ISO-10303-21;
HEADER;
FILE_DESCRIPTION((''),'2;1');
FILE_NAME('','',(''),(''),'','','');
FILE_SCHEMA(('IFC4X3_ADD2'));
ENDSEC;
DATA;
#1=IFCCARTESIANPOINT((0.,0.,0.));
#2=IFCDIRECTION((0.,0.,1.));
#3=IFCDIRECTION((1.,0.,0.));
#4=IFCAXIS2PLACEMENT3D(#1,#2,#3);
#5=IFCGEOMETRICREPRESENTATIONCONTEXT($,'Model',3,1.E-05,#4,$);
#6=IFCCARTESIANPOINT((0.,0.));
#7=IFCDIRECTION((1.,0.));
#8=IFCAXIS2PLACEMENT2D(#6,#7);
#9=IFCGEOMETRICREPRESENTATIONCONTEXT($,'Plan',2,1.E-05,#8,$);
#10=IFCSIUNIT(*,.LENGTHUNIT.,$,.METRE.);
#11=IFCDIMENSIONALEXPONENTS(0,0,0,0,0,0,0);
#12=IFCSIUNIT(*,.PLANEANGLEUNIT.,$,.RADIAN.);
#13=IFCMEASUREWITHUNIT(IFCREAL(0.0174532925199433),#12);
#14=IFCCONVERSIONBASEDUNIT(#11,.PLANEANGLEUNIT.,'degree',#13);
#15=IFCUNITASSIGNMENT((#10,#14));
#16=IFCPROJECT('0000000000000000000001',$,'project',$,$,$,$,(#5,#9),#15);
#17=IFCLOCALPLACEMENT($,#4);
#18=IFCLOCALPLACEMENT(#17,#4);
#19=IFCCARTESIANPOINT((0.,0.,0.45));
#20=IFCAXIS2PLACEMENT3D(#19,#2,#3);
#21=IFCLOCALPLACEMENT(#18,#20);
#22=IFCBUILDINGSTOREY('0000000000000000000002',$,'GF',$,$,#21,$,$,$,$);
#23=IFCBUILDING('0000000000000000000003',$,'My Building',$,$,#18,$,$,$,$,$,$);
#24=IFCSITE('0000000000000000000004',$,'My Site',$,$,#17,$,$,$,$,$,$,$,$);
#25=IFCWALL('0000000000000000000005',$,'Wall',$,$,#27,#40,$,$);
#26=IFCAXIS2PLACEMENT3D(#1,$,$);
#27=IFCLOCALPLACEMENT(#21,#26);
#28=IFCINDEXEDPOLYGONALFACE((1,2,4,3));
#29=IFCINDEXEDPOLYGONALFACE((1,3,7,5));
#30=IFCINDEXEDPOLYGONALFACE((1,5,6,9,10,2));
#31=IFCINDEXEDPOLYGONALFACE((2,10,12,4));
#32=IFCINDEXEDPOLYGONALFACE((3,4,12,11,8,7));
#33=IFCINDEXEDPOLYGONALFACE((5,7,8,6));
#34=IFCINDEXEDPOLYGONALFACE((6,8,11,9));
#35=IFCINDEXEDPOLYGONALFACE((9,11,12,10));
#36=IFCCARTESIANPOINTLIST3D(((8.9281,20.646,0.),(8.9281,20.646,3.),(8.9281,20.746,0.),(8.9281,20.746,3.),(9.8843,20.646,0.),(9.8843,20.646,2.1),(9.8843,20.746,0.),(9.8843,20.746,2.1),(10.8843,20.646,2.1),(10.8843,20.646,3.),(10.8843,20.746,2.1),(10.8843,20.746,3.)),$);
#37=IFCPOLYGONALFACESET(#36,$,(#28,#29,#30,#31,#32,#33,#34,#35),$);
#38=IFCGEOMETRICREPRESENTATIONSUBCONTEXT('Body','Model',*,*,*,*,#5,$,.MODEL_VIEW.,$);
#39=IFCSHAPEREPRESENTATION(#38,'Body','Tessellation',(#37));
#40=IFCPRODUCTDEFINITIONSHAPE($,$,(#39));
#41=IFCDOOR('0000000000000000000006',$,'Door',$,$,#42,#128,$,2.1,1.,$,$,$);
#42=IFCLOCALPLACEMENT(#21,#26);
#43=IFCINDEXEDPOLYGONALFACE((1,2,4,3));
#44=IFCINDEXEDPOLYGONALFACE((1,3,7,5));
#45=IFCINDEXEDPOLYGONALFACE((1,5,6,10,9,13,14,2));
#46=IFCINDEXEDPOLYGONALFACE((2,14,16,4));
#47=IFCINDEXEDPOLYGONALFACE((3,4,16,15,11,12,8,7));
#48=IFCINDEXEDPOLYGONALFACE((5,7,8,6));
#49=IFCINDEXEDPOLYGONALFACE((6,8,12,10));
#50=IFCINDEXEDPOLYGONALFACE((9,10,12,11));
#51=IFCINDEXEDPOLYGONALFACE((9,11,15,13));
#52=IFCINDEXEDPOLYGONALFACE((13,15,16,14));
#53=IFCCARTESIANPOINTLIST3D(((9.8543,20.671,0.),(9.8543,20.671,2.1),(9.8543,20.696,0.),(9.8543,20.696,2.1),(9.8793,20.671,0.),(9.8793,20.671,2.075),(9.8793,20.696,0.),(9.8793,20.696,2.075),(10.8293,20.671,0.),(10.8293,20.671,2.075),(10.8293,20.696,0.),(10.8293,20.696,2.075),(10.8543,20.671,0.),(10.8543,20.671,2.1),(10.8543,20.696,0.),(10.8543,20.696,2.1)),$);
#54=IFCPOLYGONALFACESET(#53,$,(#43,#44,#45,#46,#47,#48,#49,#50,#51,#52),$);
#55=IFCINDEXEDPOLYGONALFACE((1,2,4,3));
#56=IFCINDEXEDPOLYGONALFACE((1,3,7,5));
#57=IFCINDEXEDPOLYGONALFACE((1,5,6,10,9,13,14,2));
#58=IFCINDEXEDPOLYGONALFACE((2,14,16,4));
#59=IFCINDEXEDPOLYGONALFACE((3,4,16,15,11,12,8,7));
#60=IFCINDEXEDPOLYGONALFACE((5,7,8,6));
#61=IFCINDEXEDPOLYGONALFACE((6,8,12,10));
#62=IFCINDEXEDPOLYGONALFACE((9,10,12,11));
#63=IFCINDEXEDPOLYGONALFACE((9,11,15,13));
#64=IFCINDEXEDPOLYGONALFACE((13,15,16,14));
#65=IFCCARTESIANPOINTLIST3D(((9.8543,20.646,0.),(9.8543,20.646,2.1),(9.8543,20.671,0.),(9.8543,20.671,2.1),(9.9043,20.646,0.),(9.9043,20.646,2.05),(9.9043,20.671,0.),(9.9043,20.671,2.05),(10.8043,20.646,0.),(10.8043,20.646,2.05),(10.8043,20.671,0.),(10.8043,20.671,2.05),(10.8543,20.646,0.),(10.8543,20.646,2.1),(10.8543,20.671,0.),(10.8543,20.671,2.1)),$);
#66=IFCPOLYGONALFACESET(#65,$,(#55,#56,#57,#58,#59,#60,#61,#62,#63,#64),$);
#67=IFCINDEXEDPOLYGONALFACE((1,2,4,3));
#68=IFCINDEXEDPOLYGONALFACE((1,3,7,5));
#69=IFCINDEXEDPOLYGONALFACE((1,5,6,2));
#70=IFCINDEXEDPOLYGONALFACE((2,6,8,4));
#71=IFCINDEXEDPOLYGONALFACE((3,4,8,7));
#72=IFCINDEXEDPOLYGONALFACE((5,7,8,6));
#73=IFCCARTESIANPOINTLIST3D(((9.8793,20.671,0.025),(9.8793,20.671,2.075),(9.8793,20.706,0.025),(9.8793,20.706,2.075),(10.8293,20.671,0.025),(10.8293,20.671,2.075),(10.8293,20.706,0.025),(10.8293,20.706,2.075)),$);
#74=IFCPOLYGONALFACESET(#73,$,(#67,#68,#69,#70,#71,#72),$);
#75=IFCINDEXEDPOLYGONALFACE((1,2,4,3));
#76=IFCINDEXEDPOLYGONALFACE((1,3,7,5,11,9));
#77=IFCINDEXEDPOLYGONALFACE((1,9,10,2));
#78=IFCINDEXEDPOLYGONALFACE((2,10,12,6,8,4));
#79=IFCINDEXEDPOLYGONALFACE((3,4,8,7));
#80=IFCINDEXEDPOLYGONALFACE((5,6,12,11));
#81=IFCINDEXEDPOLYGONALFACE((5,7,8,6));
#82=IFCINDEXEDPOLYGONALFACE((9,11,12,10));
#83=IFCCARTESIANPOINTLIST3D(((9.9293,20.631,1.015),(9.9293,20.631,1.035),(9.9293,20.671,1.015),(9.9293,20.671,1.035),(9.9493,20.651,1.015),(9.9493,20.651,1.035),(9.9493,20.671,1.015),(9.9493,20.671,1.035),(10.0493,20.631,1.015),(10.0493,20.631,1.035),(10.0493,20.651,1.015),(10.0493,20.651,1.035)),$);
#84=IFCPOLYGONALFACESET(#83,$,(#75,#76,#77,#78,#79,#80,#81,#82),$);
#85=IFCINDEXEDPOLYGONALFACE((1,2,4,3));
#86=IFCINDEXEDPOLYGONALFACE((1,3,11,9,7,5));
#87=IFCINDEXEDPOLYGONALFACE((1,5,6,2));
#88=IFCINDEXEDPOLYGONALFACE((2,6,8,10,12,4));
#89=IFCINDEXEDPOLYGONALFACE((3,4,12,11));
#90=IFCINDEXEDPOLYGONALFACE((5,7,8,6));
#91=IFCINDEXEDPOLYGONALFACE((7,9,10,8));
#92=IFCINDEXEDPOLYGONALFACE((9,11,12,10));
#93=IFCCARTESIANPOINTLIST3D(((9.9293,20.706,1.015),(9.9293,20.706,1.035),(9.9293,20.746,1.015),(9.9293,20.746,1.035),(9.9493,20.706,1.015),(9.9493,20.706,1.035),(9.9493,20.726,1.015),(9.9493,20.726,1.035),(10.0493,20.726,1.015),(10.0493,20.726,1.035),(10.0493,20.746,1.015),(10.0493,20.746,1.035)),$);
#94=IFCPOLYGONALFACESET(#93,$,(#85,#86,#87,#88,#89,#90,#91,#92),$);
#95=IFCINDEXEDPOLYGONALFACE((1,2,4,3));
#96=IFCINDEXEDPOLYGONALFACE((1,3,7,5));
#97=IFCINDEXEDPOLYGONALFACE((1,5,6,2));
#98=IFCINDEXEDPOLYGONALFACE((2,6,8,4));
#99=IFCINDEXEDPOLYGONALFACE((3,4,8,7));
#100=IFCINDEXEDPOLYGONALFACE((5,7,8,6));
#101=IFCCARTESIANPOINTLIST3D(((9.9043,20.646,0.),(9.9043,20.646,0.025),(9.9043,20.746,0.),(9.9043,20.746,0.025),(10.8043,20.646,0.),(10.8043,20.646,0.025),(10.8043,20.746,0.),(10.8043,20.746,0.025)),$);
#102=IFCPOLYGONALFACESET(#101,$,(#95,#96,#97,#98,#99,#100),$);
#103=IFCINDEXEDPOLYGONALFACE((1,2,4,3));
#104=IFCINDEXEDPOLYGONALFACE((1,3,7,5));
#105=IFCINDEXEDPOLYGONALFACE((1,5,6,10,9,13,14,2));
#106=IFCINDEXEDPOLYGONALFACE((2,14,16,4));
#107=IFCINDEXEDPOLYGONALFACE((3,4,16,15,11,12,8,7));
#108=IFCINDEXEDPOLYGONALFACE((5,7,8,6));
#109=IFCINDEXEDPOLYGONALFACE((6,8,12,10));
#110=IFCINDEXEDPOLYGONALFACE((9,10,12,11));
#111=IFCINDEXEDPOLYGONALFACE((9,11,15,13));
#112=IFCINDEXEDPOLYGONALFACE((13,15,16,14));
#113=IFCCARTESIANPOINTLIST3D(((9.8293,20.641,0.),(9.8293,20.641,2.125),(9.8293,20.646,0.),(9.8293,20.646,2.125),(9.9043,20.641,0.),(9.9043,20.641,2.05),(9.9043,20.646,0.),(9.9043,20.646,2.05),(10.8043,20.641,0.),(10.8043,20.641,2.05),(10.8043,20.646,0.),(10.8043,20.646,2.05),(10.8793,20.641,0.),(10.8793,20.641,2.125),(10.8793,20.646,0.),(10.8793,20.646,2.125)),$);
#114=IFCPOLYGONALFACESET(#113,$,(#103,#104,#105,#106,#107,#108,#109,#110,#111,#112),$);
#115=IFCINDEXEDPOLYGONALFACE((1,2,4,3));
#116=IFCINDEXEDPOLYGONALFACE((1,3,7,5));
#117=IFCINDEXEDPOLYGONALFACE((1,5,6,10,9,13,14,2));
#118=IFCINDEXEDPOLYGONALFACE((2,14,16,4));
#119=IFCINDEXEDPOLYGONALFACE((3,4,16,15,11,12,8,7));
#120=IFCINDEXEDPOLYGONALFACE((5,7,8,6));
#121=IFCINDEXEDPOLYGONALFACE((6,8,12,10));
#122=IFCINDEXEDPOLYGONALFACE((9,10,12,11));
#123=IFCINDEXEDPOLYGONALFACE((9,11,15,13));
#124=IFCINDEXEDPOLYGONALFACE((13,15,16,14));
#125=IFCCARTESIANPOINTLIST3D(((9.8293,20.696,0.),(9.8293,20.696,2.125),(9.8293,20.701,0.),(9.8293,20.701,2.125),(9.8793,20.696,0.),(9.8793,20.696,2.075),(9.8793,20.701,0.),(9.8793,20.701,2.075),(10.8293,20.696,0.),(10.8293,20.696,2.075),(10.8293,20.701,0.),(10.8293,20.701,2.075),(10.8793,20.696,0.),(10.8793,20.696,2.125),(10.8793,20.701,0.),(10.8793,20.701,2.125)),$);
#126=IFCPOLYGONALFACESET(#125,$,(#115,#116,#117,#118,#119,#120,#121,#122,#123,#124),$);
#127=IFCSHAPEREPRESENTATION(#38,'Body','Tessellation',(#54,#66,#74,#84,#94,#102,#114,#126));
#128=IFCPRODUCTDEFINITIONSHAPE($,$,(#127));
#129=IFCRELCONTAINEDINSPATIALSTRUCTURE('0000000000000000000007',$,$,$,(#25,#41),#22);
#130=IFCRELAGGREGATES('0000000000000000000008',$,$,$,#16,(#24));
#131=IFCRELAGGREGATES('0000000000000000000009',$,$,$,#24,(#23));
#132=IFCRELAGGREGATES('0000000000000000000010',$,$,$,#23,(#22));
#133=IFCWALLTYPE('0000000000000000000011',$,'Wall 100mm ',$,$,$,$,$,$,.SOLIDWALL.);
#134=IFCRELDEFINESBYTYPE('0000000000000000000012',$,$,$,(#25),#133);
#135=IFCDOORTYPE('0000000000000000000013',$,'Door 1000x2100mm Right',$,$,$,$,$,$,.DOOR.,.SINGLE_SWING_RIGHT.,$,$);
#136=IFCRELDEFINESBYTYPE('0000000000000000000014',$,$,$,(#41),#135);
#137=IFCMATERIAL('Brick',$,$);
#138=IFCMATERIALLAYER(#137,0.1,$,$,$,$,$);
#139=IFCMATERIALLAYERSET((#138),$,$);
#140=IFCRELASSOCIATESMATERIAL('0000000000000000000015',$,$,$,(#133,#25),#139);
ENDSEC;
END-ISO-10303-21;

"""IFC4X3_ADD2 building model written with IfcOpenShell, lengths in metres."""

from ifc_helpers import new_model, entity, si_unit, converted_unit, frame, origin_with_axes, origin_2d_with_axis, place, context, subcontext, project, spatial, line, indexed_curve, outline, extrude, shape, source, transform, mapped, material, layer, layer_set, layer_usage, type_object, type_shapes, element, fill, save


model = new_model("IFC4X3_ADD2")

# Units and contexts
model_context = context("Model", 3, precision=1e-05, world=origin_with_axes())
plan_context = context("Plan", 2, precision=1e-05, world=origin_2d_with_axis())
body_context_1 = subcontext(model_context, "Body", "Model", "MODEL_VIEW")
body_context_2 = subcontext(plan_context, "Body", "Plan", "PLAN_VIEW")
ifc_project = project(units=[si_unit("LENGTHUNIT", "METRE"), converted_unit("PLANEANGLEUNIT", "degree", entity("IfcReal", 0.0174532925199433), si_unit("PLANEANGLEUNIT", "RADIAN"), dimensions=[0, 0, 0, 0, 0, 0, 0])], contexts=[model_context, plan_context])

# Site, building, storey
site_placement = place(None, origin_with_axes())
site = spatial("IfcSite", under=ifc_project, at=site_placement, Name="My Site")
building_placement = place(site_placement, origin_with_axes())
building = spatial("IfcBuilding", under=site, at=building_placement, Name="My Building")
storey_placement = place(building_placement, frame((0.0, 0.0, 0.45), z_axis=(0.0, 0.0, 1.0), x_axis=(1.0, 0.0, 0.0)))
storey = spatial("IfcBuildingStorey", under=building, at=storey_placement, Name="GF")

# Shared definitions
ifc_material = material(Name="Brick")

# Shared definitions
ifc_layer_1 = layer(ifc_material, 0.1)
ifc_layer_set_1 = layer_set([ifc_layer_1])
wall_type_1 = type_object("IfcWallType", Name="Wall 100mm ", PredefinedType="SOLIDWALL", material=ifc_layer_set_1)
shared_shape_1 = source(origin_with_axes(), body_context_1, "Body", "SweptSolid", [
    extrude(outline(indexed_curve([(0.0, 0.0), (1.0, 0.0), (1.0, 2.1), (0.0, 2.1)], segments=[line(1, 2, 3, 4, 1)])), frame((0.0, -0.6, 0.0), z_axis=(0.0, -1.0, 0.0), x_axis=(1.0, 0.0, 0.0)), (0.0, 0.0, -1.0), 1.2),
])
door_type_1 = type_object("IfcDoorType", Name="Door 1000x2100mm Right", OperationType="SINGLE_SWING_RIGHT", PredefinedType="DOOR")
shared_shape_2 = source(origin_with_axes(), body_context_1, "Body", "SweptSolid", [
    extrude(outline(indexed_curve([(0.0, 0.0), (0.0, 2.1), (1.0, 2.1), (1.0, 0.0), (0.975, 0.0), (0.975, 2.075), (0.025, 2.075), (0.025, 0.0)], segments=[line(1, 2, 3, 4, 5, 6, 7, 8, 1)])), frame((0.0, 0.025, 0.0), z_axis=(0.0, -1.0, 0.0), x_axis=(1.0, 0.0, 0.0)), (0.0, 0.0, -1.0), 0.025),
    extrude(outline(indexed_curve([(0.0, 0.0), (0.0, 2.1), (1.0, 2.1), (1.0, 0.0), (0.95, 0.0), (0.95, 2.05), (0.05, 2.05), (0.05, 0.0)], segments=[line(1, 2, 3, 4, 5, 6, 7, 8, 1)])), frame((0.0, 0.0, 0.0), z_axis=(0.0, -1.0, 0.0), x_axis=(1.0, 0.0, 0.0)), (0.0, 0.0, -1.0), 0.025),
    extrude(outline(indexed_curve([(0.0, 0.0), (0.95, 0.0), (0.95, 0.035), (0.0, 0.035)], segments=[line(1, 2, 3, 4, 1)])), frame((0.025, 0.025, 0.025), z_axis=(0.0, 0.0, 1.0), x_axis=(1.0, 0.0, 0.0)), (0.0, 0.0, 1.0), 2.05),
    extrude(outline(indexed_curve([(0.0, 0.0), (0.0, -0.04), (0.12, -0.04), (0.12, -0.02), (0.02, -0.02), (0.02, 0.0)], segments=[line(1, 2, 3, 4, 5, 6, 1)])), frame((0.075, 0.025, 1.015), z_axis=(0.0, 0.0, 1.0), x_axis=(1.0, 0.0, 0.0)), (0.0, 0.0, 1.0), 0.02),
    extrude(outline(indexed_curve([(0.0, 0.0), (0.0, 0.04), (0.12, 0.04), (0.12, 0.02), (0.02, 0.02), (0.02, 0.0)], segments=[line(1, 2, 3, 4, 5, 6, 1)])), frame((0.075, 0.06, 1.015), z_axis=(0.0, 0.0, 1.0), x_axis=(1.0, 0.0, 0.0)), (0.0, 0.0, 1.0), 0.02),
    extrude(outline(indexed_curve([(0.0, 0.0), (0.9, 0.0), (0.9, 0.1), (0.0, 0.1)], segments=[line(1, 2, 3, 4, 1)])), frame((0.05, 0.0, 0.0), z_axis=(0.0, 0.0, 1.0), x_axis=(1.0, 0.0, 0.0)), (0.0, 0.0, 1.0), 0.025),
    extrude(outline(indexed_curve([(0.0, 0.0), (0.0, 2.125), (1.05, 2.125), (1.05, 0.0), (0.975, 0.0), (0.975, 2.05), (0.075, 2.05), (0.075, 0.0)], segments=[line(1, 2, 3, 4, 5, 6, 7, 8, 1)])), frame((-0.025, -0.005, 0.0), z_axis=(0.0, -1.0, 0.0), x_axis=(1.0, 0.0, 0.0)), (0.0, 0.0, -1.0), 0.005),
    extrude(outline(indexed_curve([(0.0, 0.0), (0.0, 2.125), (1.05, 2.125), (1.05, 0.0), (1.0, 0.0), (1.0, 2.075), (0.05, 2.075), (0.05, 0.0)], segments=[line(1, 2, 3, 4, 5, 6, 7, 8, 1)])), frame((-0.025, 0.05, 0.0), z_axis=(0.0, -1.0, 0.0), x_axis=(1.0, 0.0, 0.0)), (0.0, 0.0, -1.0), 0.005),
])
shared_shape_3 = source(origin_with_axes(), body_context_2, "Body", "Curve2D", [
    entity("IfcIndexedPolyCurve", entity("IfcCartesianPointList2D", [[0.0, 0.0], [0.0, 0.05], [0.025, 0.05], [0.025, 0.025], [0.05, 0.025], [0.05, 0.0]]), [entity("IfcLineIndex", [1, 2, 3, 4, 5, 6, 1])]),
    entity("IfcIndexedPolyCurve", entity("IfcCartesianPointList2D", [[1.0, 0.0], [1.0, 0.05], [0.975, 0.05], [0.975, 0.025], [0.95, 0.025], [0.95, 0.0]]), [entity("IfcLineIndex", [1, 2, 3, 4, 5, 6, 1])]),
    entity("IfcTrimmedCurve", entity("IfcEllipse", entity("IfcAxis2Placement2D", entity("IfcCartesianPoint", [0.94, 0.05]), entity("IfcDirection", [1.0, 0.0])), 0.915, 0.95), [entity("IfcCartesianPoint", [0.94, 1.0])], [entity("IfcCartesianPoint", [0.025, 0.05])], True, "CARTESIAN"),
    entity("IfcIndexedPolyCurve", entity("IfcCartesianPointList2D", [[0.975, 0.05], [0.94, 0.05], [0.94, 1.0], [0.975, 1.0]]), [entity("IfcLineIndex", [1, 2, 3, 4, 1])]),
])
type_shapes(door_type_1, [shared_shape_2, shared_shape_3])

# Wall, opening, door
ifc_layer_usage_1 = layer_usage(ifc_layer_set_1, "AXIS2", "POSITIVE", 0.0)
wall_1_placement = place(storey_placement, frame((8.9281, 20.646, 0.0), z_axis=(0.0, 0.0, 1.0), x_axis=(1.0, 0.0, 0.0)))
wall_1 = element("IfcWall", 1, at=wall_1_placement, inside=storey, type_object=wall_type_1, material=ifc_layer_usage_1, Name="Wall", context=body_context_1, shape_type="SweptSolid", body=[
    extrude(outline(indexed_curve([(0.0, 0.0), (0.0, 0.1), (1.9562, 0.1), (1.9562, 0.0), (0.0, 0.0)], self_intersect=False)), origin_with_axes(), (0.0, 0.0, 1.0), 3.0),
])
opening_1_placement = place(wall_1_placement, frame((0.9562, 0.0, 0.0), z_axis=(0.0, 0.0, 1.0), x_axis=(1.0, 0.0, 0.0)))
opening_1 = element("IfcOpeningElement", 2, at=opening_1_placement, cuts=wall_1, PredefinedType="OPENING", context=body_context_1, shape_type="MappedRepresentation", body=[
    mapped(shared_shape_1, transform((0.0, 0.0, 0.0), x_axis=(1.0, 0.0, 0.0), y_axis=(0.0, 1.0, 0.0), z_axis=(0.0, 0.0, 1.0), scale=1.0)),
])
door_1_placement = place(opening_1_placement, frame((-0.03, 0.0, 0.0), z_axis=(0.0, 0.0, 1.0), x_axis=(1.0, 0.0, 0.0)))
door_1 = element("IfcDoor", 3, at=door_1_placement, inside=storey, type_object=door_type_1, Name="Door", OverallHeight=2.1, OverallWidth=1.0, shapes=[
    shape(body_context_1, "Body", "MappedRepresentation", [mapped(shared_shape_2, transform((0.0, 0.0, 0.0), x_axis=(1.0, 0.0, 0.0), y_axis=(0.0, 1.0, 0.0), z_axis=(0.0, 0.0, 1.0), scale=1.0))]),
    shape(body_context_2, "Body", "MappedRepresentation", [mapped(shared_shape_3, transform((0.0, 0.0, 0.0), x_axis=(1.0, 0.0, 0.0), y_axis=(0.0, 1.0, 0.0), z_axis=(0.0, 0.0, 1.0), scale=1.0))]),
])
fill(opening_1, door_1)

save(model, "model.ifc")
